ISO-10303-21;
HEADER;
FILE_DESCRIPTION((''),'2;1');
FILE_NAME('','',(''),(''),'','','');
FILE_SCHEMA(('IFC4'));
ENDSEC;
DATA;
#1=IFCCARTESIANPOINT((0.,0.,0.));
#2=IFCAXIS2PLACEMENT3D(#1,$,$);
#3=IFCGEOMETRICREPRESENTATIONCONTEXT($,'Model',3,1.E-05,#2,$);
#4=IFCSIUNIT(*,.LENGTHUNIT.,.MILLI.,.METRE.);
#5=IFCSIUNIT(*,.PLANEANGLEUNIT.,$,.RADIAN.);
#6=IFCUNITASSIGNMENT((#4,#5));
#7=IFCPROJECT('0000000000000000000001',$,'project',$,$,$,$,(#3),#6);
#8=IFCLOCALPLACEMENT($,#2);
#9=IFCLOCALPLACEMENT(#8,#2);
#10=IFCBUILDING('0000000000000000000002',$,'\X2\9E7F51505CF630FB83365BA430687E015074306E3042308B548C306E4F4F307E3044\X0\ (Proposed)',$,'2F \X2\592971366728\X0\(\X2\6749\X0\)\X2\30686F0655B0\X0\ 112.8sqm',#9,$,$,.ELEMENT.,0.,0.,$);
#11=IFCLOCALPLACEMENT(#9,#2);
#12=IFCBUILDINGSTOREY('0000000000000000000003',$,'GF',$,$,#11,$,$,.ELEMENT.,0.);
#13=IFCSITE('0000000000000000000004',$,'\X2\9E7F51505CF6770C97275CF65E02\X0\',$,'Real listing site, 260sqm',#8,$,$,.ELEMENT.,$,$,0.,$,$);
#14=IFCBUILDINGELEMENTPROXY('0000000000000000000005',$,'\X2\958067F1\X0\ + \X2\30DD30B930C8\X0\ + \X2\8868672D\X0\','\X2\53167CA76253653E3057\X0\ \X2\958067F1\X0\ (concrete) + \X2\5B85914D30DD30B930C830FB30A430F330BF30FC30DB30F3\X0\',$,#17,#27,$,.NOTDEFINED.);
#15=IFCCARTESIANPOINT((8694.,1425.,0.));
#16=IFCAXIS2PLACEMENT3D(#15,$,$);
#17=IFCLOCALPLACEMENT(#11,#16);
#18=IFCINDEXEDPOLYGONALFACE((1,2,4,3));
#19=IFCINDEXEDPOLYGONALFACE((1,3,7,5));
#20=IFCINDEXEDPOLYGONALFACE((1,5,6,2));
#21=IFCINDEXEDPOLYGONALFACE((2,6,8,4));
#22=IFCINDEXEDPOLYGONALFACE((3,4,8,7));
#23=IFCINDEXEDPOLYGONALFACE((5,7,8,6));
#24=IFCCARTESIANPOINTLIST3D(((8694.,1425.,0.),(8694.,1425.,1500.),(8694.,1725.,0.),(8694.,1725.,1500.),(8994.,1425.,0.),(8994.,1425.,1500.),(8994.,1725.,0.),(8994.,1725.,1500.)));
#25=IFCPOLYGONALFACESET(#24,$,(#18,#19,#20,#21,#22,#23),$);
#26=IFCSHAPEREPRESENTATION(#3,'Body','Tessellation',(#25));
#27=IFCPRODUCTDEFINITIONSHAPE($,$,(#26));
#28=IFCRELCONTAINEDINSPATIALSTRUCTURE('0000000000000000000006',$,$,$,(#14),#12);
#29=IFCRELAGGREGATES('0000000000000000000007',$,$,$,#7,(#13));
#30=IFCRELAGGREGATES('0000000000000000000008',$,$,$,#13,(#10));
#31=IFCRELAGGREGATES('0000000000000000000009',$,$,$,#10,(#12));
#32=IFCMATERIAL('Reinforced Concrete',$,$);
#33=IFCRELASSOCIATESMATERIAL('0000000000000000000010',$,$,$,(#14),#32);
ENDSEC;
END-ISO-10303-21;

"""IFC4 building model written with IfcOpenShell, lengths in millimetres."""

from ifc_helpers import new_model, si_unit, frame, frame_2d, origin, place, context, project, spatial, rectangle, extrude, material, element, save


model = new_model("IFC4")

# Units and contexts
model_context = context("Model", 3, precision=1e-05, world=origin())
ifc_project = project(units=[si_unit("LENGTHUNIT", "METRE", prefix="MILLI"), si_unit("PLANEANGLEUNIT", "RADIAN")], contexts=[model_context])

# Site, building, storey
site_placement = place(None, origin())
site = spatial("IfcSite", under=ifc_project, at=site_placement, Name="鹿児島県霧島市", ObjectType="Real listing site, 260sqm", CompositionType="ELEMENT", RefElevation=0.0)
building_placement = place(site_placement, origin())
building = spatial("IfcBuilding", under=site, at=building_placement, Name="鹿児島・茶室と縁側のある和の住まい (Proposed)", ObjectType="2F 天然木(杉)と漆喰 112.8sqm", CompositionType="ELEMENT", ElevationOfRefHeight=0.0, ElevationOfTerrain=0.0)
storey_placement = place(building_placement, origin())
storey = spatial("IfcBuildingStorey", under=building, at=storey_placement, Name="GF", CompositionType="ELEMENT", Elevation=0.0)

# Shared definitions
ifc_material_1 = material(Name="Reinforced Concrete")

# Building element proxy
proxy_placement = place(storey_placement, frame((8694.0, 1425.0, 0.0)))
element("IfcBuildingElementProxy", 1, at=proxy_placement, inside=storey, material=ifc_material_1, Name="門柱 + ポスト + 表札", Description="化粧打放し 門柱 (concrete) + 宅配ポスト・インターホン", PredefinedType="NOTDEFINED", context=model_context, shape_type="SweptSolid", body=[
    extrude(rectangle(XDim=300.0, YDim=300.0, at=frame_2d((150.0, 150.0))), frame((8694.0, 1425.0, 0.0)), (0.0, 0.0, 1.0), 1500.0),
])

save(model, "model.ifc")
